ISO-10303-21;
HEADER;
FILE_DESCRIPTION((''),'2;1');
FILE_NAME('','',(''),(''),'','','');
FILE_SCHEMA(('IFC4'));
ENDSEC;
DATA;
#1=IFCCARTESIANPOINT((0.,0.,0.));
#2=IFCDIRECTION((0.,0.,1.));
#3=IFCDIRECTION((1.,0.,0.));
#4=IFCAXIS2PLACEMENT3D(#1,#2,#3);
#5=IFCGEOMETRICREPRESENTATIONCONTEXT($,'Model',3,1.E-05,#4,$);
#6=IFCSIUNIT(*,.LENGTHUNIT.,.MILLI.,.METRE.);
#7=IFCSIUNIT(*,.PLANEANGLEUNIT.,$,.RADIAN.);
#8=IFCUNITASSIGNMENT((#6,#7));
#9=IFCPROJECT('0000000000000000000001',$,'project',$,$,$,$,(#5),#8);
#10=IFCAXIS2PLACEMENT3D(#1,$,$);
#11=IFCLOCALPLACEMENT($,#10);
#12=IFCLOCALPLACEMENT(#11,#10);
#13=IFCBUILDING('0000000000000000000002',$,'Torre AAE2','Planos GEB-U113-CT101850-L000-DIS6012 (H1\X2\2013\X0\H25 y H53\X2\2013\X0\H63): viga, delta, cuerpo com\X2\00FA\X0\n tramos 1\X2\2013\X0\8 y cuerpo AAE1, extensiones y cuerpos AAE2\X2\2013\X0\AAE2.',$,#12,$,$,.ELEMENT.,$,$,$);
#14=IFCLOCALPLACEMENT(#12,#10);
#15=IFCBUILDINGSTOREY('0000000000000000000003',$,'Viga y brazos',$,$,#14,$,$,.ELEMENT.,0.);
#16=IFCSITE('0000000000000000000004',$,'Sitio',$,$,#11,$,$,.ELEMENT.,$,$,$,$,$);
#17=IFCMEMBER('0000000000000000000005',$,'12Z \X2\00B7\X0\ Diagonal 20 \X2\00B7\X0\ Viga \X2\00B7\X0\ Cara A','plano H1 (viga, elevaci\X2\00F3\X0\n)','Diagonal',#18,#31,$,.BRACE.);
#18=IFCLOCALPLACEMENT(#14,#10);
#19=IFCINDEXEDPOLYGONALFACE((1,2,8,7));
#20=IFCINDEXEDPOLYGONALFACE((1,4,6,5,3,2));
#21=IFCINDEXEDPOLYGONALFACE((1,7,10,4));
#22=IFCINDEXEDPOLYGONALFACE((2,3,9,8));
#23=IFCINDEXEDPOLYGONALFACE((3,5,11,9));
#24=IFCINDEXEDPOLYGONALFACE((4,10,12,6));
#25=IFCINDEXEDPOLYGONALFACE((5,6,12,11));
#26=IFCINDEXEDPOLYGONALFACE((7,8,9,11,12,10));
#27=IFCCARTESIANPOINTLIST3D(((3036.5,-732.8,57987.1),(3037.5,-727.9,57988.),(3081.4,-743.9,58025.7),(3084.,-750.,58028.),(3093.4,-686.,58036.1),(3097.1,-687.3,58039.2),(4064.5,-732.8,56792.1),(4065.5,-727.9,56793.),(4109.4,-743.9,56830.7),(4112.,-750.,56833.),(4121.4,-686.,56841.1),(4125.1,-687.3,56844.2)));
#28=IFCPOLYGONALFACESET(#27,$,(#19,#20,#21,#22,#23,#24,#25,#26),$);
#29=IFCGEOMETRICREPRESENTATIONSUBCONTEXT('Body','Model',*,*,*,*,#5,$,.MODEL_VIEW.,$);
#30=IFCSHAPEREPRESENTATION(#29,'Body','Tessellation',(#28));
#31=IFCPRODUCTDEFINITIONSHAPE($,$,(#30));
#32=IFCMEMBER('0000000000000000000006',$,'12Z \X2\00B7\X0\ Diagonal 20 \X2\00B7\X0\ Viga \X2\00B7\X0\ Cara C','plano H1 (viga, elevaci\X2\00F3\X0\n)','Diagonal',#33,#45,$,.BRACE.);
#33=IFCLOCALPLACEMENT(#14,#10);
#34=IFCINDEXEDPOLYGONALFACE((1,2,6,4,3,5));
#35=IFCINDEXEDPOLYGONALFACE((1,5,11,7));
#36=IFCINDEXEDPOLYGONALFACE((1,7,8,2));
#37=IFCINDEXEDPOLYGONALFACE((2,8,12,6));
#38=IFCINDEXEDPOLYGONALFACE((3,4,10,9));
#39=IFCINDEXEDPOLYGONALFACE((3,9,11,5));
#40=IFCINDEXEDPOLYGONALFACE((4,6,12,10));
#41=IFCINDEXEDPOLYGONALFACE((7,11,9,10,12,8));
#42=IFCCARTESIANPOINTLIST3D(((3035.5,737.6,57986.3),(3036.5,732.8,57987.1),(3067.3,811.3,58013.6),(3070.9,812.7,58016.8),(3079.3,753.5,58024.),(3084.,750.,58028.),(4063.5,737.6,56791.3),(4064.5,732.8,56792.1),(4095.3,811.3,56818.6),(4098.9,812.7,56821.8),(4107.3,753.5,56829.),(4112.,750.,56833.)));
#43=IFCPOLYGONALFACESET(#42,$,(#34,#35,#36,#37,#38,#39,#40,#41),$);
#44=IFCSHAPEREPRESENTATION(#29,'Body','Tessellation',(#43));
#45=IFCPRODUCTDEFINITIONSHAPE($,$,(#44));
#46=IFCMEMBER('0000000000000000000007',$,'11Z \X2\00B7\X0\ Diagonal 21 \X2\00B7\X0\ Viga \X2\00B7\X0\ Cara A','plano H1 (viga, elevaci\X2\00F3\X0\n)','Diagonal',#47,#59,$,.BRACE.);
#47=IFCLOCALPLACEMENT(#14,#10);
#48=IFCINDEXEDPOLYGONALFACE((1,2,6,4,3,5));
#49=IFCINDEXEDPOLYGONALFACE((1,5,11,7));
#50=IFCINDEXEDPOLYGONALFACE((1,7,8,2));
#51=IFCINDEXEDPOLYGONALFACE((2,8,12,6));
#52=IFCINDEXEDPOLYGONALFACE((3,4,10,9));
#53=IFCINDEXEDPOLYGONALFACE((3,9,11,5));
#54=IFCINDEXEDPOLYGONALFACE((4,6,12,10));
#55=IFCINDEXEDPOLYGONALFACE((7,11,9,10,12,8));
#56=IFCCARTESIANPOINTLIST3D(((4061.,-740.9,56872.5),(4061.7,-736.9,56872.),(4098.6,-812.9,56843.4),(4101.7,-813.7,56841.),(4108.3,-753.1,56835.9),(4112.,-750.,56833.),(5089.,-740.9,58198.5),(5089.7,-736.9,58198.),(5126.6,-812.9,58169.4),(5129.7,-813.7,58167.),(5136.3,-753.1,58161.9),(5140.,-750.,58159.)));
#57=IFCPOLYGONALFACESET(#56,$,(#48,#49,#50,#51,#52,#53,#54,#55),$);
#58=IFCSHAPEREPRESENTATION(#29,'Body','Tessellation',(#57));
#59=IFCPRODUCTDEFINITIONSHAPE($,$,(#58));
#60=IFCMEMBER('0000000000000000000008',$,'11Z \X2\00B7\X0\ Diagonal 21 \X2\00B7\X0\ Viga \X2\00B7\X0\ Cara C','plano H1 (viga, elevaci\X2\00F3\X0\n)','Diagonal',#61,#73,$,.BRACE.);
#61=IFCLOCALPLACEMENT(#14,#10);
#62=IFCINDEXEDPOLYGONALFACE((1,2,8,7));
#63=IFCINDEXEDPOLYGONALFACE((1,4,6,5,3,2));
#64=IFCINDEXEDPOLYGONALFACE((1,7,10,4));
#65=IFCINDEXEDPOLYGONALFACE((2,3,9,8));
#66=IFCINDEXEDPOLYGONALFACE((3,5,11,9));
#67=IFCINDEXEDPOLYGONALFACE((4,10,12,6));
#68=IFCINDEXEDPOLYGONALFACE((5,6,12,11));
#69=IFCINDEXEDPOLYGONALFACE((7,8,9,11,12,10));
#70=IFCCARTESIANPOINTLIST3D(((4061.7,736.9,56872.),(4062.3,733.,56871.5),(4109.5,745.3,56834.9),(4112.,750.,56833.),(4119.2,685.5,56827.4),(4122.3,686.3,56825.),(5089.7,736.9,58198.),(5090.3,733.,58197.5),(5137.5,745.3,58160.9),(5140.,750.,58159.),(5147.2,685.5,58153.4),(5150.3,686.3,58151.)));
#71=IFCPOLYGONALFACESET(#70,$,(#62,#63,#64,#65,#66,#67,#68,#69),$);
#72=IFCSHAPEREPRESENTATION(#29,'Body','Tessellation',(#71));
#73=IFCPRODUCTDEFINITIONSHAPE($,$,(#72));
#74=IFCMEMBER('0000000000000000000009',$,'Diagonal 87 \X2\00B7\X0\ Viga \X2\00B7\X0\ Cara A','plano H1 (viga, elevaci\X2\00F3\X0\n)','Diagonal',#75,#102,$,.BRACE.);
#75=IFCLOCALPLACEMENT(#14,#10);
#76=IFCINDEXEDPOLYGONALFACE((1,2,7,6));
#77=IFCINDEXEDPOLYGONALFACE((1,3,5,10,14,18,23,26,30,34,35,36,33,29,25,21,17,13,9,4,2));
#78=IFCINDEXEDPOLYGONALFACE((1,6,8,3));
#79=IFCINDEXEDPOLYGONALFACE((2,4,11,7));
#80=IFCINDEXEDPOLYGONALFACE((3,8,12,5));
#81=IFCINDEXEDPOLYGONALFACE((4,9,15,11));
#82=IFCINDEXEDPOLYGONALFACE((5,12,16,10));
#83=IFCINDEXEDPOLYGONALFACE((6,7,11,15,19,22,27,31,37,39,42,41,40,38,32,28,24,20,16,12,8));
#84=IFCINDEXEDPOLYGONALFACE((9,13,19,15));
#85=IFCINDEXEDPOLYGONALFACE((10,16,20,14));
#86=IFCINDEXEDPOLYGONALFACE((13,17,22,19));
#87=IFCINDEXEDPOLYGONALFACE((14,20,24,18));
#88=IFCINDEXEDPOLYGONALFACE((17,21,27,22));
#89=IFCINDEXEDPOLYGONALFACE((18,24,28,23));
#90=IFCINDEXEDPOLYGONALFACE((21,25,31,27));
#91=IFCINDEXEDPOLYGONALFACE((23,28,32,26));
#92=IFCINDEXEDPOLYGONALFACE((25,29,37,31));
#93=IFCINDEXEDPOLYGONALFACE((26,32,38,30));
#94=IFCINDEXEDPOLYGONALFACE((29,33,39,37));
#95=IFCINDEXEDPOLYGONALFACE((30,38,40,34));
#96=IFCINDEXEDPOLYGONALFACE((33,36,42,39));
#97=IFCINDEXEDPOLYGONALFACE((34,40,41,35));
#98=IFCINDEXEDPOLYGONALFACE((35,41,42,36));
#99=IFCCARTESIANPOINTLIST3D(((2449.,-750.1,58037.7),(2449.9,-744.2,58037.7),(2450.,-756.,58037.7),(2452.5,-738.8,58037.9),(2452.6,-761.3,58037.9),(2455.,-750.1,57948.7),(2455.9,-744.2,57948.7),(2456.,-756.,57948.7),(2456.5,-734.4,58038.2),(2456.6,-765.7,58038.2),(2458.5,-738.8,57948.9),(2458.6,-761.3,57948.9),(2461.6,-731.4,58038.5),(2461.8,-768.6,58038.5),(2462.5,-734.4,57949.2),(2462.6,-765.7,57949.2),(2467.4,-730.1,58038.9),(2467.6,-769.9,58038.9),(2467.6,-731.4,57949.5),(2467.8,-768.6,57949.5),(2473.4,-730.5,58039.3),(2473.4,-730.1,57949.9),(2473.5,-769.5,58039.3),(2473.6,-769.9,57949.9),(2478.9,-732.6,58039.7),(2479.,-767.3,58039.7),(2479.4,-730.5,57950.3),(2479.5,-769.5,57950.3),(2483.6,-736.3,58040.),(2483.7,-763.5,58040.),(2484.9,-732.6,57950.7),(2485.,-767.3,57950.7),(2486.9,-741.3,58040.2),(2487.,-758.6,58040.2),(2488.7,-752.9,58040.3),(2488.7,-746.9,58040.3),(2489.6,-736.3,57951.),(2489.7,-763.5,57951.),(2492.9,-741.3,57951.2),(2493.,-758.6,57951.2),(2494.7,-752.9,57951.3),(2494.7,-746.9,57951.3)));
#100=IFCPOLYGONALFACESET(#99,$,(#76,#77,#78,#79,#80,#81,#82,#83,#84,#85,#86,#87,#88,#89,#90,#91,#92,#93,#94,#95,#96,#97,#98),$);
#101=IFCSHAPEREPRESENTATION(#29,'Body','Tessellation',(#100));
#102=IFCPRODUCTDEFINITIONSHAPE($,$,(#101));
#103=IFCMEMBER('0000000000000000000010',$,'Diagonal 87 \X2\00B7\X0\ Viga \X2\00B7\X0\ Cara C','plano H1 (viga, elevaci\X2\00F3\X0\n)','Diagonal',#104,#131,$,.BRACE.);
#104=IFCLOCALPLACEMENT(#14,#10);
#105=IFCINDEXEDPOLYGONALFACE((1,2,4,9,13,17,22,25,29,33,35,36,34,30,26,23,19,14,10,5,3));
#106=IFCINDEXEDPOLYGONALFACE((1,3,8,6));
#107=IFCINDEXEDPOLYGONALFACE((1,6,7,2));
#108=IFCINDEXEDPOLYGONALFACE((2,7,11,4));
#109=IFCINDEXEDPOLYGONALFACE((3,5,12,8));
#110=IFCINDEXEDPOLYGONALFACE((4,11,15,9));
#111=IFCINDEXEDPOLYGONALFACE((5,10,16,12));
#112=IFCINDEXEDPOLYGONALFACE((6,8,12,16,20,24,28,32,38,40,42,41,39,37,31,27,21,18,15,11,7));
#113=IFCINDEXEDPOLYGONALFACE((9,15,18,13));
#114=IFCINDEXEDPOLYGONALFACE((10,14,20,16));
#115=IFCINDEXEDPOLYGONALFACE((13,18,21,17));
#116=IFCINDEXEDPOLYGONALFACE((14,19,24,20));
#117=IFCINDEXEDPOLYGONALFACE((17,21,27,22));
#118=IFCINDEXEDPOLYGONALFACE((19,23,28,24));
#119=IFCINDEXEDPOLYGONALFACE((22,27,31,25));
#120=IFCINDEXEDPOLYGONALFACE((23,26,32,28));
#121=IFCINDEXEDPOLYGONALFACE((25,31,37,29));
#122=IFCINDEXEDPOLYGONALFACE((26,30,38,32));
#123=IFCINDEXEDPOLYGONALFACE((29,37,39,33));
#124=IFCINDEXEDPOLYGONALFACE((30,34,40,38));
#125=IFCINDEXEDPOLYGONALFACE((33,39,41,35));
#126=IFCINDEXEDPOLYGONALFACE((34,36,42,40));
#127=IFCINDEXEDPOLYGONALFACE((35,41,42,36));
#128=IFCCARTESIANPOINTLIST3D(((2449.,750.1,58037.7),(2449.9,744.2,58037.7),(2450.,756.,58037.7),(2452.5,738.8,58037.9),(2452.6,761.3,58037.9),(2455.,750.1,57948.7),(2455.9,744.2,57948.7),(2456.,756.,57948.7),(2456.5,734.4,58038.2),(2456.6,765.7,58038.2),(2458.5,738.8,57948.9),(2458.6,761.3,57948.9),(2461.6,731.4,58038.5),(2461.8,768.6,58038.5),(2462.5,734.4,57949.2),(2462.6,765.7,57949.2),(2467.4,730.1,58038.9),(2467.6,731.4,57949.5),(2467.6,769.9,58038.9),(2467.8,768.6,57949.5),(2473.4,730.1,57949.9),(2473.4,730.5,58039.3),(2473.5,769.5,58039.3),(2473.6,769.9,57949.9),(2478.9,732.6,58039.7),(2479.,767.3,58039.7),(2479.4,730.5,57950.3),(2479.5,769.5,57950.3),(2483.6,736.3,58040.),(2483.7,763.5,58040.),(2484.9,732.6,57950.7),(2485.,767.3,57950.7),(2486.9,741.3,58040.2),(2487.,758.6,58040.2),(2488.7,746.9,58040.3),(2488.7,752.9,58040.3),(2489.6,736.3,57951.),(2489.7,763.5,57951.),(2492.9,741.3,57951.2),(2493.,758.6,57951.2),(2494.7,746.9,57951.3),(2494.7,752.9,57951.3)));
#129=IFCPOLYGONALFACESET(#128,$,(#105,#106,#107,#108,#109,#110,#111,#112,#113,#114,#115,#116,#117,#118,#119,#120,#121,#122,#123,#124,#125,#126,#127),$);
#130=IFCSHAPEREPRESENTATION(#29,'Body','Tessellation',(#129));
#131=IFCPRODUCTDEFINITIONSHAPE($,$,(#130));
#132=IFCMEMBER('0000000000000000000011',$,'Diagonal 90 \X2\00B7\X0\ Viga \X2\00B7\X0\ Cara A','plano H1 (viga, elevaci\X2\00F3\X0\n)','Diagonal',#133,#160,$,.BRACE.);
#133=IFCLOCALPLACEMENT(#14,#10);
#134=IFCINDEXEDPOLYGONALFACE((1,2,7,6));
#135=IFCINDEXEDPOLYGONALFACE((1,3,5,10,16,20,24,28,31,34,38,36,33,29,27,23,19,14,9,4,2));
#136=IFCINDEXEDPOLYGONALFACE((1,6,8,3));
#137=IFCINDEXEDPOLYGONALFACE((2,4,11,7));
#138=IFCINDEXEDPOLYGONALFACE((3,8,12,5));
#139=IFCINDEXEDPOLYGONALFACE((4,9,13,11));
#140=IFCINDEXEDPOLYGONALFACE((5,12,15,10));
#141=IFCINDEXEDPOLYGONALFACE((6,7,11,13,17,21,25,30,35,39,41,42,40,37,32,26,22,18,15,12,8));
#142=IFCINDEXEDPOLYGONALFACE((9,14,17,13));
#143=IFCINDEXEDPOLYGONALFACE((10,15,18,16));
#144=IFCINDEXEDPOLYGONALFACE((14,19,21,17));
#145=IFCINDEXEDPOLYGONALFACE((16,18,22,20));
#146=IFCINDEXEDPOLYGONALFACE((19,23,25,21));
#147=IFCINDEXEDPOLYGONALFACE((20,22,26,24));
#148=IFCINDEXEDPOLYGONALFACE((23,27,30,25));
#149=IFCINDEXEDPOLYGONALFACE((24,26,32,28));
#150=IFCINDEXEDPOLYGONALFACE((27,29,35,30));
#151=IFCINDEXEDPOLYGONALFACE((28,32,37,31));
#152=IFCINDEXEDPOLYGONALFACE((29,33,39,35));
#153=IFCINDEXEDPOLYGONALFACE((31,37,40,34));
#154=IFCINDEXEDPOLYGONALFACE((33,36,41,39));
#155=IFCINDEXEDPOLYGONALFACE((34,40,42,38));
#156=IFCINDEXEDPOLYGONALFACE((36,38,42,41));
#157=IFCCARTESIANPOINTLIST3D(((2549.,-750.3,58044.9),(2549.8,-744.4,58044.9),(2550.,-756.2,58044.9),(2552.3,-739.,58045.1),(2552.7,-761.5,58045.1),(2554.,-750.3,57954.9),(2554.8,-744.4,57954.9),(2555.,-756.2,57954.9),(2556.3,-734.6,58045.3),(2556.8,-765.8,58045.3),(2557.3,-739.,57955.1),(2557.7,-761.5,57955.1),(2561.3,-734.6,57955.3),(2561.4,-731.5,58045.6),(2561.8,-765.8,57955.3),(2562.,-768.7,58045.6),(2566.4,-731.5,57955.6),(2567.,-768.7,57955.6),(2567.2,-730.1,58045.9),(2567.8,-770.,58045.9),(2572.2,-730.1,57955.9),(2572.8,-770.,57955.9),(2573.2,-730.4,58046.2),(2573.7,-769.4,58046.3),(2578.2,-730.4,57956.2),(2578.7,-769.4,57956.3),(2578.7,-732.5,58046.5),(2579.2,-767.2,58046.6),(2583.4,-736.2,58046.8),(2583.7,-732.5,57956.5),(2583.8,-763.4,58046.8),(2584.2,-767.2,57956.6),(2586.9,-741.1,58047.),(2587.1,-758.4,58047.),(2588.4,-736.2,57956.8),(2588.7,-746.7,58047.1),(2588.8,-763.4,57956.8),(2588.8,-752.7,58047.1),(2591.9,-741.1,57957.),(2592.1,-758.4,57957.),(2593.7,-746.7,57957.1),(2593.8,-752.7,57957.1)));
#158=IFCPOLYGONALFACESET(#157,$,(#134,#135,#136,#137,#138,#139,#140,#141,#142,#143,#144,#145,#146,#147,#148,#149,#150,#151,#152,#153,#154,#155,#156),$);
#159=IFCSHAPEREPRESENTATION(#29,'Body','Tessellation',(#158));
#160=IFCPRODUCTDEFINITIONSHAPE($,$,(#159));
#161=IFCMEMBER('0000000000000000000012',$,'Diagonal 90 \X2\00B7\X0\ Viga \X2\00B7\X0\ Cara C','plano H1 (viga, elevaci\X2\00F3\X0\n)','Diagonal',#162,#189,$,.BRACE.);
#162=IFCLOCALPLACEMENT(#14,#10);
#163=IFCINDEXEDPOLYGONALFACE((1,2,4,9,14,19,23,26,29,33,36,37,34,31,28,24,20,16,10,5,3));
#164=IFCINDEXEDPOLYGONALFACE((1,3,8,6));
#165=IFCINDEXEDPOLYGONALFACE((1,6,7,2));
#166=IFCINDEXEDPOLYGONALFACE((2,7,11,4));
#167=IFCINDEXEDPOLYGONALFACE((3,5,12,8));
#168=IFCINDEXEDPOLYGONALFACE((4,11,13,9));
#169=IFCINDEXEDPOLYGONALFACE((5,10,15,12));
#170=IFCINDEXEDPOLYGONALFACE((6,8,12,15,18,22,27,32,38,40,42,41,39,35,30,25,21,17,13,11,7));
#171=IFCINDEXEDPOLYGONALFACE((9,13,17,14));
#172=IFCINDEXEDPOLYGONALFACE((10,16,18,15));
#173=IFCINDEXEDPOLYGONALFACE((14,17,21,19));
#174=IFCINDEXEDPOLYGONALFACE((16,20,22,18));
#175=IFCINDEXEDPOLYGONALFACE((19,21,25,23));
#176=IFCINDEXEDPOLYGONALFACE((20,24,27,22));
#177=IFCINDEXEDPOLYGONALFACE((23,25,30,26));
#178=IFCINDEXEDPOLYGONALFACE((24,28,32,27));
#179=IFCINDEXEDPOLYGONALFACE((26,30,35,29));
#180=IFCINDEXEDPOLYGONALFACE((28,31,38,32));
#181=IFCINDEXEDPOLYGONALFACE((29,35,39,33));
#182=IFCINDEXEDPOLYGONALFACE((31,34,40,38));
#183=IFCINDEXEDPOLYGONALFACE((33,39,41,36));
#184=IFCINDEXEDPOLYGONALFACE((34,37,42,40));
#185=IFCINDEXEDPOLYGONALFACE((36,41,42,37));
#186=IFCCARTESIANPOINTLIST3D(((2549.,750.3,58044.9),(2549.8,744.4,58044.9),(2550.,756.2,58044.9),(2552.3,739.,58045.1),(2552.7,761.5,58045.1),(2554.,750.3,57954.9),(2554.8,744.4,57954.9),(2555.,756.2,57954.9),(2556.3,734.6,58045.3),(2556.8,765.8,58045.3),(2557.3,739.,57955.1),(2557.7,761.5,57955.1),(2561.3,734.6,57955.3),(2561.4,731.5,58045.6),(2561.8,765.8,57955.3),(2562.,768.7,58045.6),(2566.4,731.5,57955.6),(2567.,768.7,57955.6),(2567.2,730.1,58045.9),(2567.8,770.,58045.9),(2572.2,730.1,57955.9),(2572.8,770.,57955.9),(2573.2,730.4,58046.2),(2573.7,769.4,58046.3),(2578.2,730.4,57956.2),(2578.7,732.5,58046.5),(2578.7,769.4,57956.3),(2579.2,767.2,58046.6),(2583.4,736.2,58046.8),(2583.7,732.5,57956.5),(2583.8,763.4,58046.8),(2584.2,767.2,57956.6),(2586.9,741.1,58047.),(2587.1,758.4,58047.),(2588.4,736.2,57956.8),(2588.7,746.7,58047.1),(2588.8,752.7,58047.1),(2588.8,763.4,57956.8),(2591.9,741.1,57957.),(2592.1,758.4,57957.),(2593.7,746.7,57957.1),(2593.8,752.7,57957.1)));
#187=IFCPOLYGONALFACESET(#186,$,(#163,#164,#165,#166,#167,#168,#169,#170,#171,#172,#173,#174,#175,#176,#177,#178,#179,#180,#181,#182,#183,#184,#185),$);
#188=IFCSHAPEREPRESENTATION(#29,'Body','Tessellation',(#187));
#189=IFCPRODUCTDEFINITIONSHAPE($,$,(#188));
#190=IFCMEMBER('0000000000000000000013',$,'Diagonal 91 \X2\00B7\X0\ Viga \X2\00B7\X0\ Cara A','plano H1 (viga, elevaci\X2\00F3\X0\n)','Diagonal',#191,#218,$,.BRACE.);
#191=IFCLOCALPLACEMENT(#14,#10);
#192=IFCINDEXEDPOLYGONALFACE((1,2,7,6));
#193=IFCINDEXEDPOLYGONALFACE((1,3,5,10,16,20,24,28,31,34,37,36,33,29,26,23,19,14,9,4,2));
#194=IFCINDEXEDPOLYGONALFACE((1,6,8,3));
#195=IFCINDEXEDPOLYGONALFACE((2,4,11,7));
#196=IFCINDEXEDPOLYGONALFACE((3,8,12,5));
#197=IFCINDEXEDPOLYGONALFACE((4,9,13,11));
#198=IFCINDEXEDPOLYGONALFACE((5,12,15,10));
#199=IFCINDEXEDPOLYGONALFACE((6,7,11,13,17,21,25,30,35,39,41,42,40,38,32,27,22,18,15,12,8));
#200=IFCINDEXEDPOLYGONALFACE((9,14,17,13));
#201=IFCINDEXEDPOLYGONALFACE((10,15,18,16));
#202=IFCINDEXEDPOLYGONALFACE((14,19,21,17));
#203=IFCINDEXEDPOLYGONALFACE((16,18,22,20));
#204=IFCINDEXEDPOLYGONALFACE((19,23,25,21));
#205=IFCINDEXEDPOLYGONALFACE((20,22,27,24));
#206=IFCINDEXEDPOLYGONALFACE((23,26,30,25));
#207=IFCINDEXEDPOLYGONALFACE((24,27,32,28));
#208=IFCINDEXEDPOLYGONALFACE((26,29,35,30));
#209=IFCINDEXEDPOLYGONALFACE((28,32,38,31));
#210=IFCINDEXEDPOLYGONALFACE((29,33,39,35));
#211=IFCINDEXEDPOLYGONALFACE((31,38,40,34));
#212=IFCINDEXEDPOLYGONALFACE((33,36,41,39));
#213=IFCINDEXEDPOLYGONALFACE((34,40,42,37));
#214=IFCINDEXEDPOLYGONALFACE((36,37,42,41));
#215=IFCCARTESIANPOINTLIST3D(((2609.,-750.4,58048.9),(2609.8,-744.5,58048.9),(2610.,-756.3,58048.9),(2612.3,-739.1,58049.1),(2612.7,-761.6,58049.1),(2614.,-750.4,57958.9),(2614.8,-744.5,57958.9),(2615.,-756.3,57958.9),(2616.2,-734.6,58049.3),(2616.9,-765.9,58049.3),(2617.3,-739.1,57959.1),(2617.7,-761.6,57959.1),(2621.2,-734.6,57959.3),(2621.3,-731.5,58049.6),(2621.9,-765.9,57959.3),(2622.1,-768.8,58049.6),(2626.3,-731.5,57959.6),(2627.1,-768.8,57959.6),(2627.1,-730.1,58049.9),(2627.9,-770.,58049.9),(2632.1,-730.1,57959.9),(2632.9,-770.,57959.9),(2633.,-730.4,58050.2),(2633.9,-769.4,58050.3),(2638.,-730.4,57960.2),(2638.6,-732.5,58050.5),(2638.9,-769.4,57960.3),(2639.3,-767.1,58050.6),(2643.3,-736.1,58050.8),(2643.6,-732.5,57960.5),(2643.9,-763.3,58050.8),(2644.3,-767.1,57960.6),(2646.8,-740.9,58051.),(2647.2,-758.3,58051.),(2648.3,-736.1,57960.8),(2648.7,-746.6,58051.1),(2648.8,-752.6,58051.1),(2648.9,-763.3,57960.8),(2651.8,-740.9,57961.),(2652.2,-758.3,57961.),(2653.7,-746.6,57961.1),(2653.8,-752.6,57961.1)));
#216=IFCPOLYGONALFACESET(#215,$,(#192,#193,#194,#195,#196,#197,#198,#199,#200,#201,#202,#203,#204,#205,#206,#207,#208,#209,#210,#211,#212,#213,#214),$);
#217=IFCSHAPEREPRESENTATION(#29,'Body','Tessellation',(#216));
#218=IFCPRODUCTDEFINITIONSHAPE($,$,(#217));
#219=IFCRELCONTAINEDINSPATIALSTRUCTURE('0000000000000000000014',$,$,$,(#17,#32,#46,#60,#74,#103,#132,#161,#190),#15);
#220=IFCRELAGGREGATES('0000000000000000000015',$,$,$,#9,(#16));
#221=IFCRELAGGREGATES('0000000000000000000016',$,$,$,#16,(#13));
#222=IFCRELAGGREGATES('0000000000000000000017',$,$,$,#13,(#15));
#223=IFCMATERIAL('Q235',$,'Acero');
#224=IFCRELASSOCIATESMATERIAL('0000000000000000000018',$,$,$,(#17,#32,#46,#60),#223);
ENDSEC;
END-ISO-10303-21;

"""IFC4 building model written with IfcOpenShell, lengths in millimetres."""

from ifc_helpers import new_model, si_unit, frame, frame_2d, origin, origin_with_axes, place, context, subcontext, project, spatial, circle, l_section, extrude, material, element, save


model = new_model("IFC4")

# Units and contexts
model_context = context("Model", 3, precision=1e-05, world=origin_with_axes())
body_context = subcontext(model_context, "Body", "Model", "MODEL_VIEW")
ifc_project = project(units=[si_unit("LENGTHUNIT", "METRE", prefix="MILLI"), si_unit("PLANEANGLEUNIT", "RADIAN")], contexts=[model_context])

# Site, building, storey
site_placement = place(None, origin())
site = spatial("IfcSite", under=ifc_project, at=site_placement, Name="Sitio", CompositionType="ELEMENT")
building_placement = place(site_placement, origin())
building = spatial("IfcBuilding", under=site, at=building_placement, Name="Torre AAE2", Description="Planos GEB-U113-CT101850-L000-DIS6012 (H1–H25 y H53–H63): viga, delta, cuerpo común tramos 1–8 y cuerpo AAE1, extensiones y cuerpos AAE2–AAE2.", CompositionType="ELEMENT")
storey_placement = place(building_placement, origin())
storey = spatial("IfcBuildingStorey", under=building, at=storey_placement, Name="Viga y brazos", CompositionType="ELEMENT", Elevation=0.0)

# Members
ifc_material = material(Name="Q235", Category="Acero")
for number, where, z_axis, x_axis, name in (
    (1, (3084.0, -750.0, 58028.0), (0.652149, 0.0, -0.758091), (-0.730962, 0.265126, -0.628811), "12Z · Diagonal 20 · Viga · Cara A"),
    (2, (3084.0, 750.0, 58028.0), (0.652149, 0.0, -0.758091), (-0.730962, -0.265126, -0.628811), "12Z · Diagonal 20 · Viga · Cara C"),
):
    element("IfcMember", number, at=place(storey_placement, frame(where, z_axis=z_axis, x_axis=x_axis)), inside=storey, material=ifc_material, Name=name, Description="plano H1 (viga, elevación)", ObjectType="Diagonal", PredefinedType="BRACE", context=body_context, shape_type="SweptSolid", body=[
        extrude(l_section(Depth=65.0, Width=65.0, Thickness=5.0, at=frame_2d((32.5, 32.5))), None, (0.0, 0.0, 1.0), 1576.3),
    ])
for number, where, z_axis, x_axis, name in (
    (3, (4112.0, -750.0, 56833.0), (0.612702, 0.0, 0.790314), (-0.774192, 0.200958, 0.600203), "11Z · Diagonal 21 · Viga · Cara A"),
    (4, (4112.0, 750.0, 56833.0), (0.612702, 0.0, 0.790314), (-0.774192, -0.200958, 0.600203), "11Z · Diagonal 21 · Viga · Cara C"),
):
    element("IfcMember", number, at=place(storey_placement, frame(where, z_axis=z_axis, x_axis=x_axis)), inside=storey, material=ifc_material, Name=name, Description="plano H1 (viga, elevación)", ObjectType="Diagonal", PredefinedType="BRACE", context=body_context, shape_type="SweptSolid", body=[
        extrude(l_section(Depth=65.0, Width=65.0, Thickness=4.0, at=frame_2d((32.5, 32.5))), None, (0.0, 0.0, 1.0), 1677.8),
    ])
for number, where, z_axis, x_axis, name in (
    (5, (2475.0, -750.0, 57950.0), (-0.067263, 0.0, 0.997735), (-0.954577, 0.290933, -0.064353), "Diagonal 87 · Viga · Cara A"),
    (6, (2475.0, 750.0, 57950.0), (-0.067263, 0.0, 0.997735), (-0.954577, -0.290933, -0.064353), "Diagonal 87 · Viga · Cara C"),
):
    element("IfcMember", number, at=place(storey_placement, frame(where, z_axis=z_axis, x_axis=x_axis)), inside=storey, Name=name, Description="plano H1 (viga, elevación)", ObjectType="Diagonal", PredefinedType="BRACE", context=body_context, shape_type="SweptSolid", body=[
        extrude(circle(Radius=20.0), None, (0.0, 0.0, 1.0), 89.2),
    ])
for number, where, z_axis, x_axis, name in (
    (7, (2574.0, -750.0, 57956.0), (-0.05547, 0.0, 0.99846), (-0.958408, 0.280391, -0.053245), "Diagonal 90 · Viga · Cara A"),
    (8, (2574.0, 750.0, 57956.0), (-0.05547, 0.0, 0.99846), (-0.958408, -0.280391, -0.053245), "Diagonal 90 · Viga · Cara C"),
    (9, (2634.0, -750.0, 57960.0), (-0.05547, 0.0, 0.99846), (-0.960111, 0.274484, -0.05334), "Diagonal 91 · Viga · Cara A"),
):
    element("IfcMember", number, at=place(storey_placement, frame(where, z_axis=z_axis, x_axis=x_axis)), inside=storey, Name=name, Description="plano H1 (viga, elevación)", ObjectType="Diagonal", PredefinedType="BRACE", context=body_context, shape_type="SweptSolid", body=[
        extrude(circle(Radius=20.0), None, (0.0, 0.0, 1.0), 90.1),
    ])

save(model, "model.ifc")
